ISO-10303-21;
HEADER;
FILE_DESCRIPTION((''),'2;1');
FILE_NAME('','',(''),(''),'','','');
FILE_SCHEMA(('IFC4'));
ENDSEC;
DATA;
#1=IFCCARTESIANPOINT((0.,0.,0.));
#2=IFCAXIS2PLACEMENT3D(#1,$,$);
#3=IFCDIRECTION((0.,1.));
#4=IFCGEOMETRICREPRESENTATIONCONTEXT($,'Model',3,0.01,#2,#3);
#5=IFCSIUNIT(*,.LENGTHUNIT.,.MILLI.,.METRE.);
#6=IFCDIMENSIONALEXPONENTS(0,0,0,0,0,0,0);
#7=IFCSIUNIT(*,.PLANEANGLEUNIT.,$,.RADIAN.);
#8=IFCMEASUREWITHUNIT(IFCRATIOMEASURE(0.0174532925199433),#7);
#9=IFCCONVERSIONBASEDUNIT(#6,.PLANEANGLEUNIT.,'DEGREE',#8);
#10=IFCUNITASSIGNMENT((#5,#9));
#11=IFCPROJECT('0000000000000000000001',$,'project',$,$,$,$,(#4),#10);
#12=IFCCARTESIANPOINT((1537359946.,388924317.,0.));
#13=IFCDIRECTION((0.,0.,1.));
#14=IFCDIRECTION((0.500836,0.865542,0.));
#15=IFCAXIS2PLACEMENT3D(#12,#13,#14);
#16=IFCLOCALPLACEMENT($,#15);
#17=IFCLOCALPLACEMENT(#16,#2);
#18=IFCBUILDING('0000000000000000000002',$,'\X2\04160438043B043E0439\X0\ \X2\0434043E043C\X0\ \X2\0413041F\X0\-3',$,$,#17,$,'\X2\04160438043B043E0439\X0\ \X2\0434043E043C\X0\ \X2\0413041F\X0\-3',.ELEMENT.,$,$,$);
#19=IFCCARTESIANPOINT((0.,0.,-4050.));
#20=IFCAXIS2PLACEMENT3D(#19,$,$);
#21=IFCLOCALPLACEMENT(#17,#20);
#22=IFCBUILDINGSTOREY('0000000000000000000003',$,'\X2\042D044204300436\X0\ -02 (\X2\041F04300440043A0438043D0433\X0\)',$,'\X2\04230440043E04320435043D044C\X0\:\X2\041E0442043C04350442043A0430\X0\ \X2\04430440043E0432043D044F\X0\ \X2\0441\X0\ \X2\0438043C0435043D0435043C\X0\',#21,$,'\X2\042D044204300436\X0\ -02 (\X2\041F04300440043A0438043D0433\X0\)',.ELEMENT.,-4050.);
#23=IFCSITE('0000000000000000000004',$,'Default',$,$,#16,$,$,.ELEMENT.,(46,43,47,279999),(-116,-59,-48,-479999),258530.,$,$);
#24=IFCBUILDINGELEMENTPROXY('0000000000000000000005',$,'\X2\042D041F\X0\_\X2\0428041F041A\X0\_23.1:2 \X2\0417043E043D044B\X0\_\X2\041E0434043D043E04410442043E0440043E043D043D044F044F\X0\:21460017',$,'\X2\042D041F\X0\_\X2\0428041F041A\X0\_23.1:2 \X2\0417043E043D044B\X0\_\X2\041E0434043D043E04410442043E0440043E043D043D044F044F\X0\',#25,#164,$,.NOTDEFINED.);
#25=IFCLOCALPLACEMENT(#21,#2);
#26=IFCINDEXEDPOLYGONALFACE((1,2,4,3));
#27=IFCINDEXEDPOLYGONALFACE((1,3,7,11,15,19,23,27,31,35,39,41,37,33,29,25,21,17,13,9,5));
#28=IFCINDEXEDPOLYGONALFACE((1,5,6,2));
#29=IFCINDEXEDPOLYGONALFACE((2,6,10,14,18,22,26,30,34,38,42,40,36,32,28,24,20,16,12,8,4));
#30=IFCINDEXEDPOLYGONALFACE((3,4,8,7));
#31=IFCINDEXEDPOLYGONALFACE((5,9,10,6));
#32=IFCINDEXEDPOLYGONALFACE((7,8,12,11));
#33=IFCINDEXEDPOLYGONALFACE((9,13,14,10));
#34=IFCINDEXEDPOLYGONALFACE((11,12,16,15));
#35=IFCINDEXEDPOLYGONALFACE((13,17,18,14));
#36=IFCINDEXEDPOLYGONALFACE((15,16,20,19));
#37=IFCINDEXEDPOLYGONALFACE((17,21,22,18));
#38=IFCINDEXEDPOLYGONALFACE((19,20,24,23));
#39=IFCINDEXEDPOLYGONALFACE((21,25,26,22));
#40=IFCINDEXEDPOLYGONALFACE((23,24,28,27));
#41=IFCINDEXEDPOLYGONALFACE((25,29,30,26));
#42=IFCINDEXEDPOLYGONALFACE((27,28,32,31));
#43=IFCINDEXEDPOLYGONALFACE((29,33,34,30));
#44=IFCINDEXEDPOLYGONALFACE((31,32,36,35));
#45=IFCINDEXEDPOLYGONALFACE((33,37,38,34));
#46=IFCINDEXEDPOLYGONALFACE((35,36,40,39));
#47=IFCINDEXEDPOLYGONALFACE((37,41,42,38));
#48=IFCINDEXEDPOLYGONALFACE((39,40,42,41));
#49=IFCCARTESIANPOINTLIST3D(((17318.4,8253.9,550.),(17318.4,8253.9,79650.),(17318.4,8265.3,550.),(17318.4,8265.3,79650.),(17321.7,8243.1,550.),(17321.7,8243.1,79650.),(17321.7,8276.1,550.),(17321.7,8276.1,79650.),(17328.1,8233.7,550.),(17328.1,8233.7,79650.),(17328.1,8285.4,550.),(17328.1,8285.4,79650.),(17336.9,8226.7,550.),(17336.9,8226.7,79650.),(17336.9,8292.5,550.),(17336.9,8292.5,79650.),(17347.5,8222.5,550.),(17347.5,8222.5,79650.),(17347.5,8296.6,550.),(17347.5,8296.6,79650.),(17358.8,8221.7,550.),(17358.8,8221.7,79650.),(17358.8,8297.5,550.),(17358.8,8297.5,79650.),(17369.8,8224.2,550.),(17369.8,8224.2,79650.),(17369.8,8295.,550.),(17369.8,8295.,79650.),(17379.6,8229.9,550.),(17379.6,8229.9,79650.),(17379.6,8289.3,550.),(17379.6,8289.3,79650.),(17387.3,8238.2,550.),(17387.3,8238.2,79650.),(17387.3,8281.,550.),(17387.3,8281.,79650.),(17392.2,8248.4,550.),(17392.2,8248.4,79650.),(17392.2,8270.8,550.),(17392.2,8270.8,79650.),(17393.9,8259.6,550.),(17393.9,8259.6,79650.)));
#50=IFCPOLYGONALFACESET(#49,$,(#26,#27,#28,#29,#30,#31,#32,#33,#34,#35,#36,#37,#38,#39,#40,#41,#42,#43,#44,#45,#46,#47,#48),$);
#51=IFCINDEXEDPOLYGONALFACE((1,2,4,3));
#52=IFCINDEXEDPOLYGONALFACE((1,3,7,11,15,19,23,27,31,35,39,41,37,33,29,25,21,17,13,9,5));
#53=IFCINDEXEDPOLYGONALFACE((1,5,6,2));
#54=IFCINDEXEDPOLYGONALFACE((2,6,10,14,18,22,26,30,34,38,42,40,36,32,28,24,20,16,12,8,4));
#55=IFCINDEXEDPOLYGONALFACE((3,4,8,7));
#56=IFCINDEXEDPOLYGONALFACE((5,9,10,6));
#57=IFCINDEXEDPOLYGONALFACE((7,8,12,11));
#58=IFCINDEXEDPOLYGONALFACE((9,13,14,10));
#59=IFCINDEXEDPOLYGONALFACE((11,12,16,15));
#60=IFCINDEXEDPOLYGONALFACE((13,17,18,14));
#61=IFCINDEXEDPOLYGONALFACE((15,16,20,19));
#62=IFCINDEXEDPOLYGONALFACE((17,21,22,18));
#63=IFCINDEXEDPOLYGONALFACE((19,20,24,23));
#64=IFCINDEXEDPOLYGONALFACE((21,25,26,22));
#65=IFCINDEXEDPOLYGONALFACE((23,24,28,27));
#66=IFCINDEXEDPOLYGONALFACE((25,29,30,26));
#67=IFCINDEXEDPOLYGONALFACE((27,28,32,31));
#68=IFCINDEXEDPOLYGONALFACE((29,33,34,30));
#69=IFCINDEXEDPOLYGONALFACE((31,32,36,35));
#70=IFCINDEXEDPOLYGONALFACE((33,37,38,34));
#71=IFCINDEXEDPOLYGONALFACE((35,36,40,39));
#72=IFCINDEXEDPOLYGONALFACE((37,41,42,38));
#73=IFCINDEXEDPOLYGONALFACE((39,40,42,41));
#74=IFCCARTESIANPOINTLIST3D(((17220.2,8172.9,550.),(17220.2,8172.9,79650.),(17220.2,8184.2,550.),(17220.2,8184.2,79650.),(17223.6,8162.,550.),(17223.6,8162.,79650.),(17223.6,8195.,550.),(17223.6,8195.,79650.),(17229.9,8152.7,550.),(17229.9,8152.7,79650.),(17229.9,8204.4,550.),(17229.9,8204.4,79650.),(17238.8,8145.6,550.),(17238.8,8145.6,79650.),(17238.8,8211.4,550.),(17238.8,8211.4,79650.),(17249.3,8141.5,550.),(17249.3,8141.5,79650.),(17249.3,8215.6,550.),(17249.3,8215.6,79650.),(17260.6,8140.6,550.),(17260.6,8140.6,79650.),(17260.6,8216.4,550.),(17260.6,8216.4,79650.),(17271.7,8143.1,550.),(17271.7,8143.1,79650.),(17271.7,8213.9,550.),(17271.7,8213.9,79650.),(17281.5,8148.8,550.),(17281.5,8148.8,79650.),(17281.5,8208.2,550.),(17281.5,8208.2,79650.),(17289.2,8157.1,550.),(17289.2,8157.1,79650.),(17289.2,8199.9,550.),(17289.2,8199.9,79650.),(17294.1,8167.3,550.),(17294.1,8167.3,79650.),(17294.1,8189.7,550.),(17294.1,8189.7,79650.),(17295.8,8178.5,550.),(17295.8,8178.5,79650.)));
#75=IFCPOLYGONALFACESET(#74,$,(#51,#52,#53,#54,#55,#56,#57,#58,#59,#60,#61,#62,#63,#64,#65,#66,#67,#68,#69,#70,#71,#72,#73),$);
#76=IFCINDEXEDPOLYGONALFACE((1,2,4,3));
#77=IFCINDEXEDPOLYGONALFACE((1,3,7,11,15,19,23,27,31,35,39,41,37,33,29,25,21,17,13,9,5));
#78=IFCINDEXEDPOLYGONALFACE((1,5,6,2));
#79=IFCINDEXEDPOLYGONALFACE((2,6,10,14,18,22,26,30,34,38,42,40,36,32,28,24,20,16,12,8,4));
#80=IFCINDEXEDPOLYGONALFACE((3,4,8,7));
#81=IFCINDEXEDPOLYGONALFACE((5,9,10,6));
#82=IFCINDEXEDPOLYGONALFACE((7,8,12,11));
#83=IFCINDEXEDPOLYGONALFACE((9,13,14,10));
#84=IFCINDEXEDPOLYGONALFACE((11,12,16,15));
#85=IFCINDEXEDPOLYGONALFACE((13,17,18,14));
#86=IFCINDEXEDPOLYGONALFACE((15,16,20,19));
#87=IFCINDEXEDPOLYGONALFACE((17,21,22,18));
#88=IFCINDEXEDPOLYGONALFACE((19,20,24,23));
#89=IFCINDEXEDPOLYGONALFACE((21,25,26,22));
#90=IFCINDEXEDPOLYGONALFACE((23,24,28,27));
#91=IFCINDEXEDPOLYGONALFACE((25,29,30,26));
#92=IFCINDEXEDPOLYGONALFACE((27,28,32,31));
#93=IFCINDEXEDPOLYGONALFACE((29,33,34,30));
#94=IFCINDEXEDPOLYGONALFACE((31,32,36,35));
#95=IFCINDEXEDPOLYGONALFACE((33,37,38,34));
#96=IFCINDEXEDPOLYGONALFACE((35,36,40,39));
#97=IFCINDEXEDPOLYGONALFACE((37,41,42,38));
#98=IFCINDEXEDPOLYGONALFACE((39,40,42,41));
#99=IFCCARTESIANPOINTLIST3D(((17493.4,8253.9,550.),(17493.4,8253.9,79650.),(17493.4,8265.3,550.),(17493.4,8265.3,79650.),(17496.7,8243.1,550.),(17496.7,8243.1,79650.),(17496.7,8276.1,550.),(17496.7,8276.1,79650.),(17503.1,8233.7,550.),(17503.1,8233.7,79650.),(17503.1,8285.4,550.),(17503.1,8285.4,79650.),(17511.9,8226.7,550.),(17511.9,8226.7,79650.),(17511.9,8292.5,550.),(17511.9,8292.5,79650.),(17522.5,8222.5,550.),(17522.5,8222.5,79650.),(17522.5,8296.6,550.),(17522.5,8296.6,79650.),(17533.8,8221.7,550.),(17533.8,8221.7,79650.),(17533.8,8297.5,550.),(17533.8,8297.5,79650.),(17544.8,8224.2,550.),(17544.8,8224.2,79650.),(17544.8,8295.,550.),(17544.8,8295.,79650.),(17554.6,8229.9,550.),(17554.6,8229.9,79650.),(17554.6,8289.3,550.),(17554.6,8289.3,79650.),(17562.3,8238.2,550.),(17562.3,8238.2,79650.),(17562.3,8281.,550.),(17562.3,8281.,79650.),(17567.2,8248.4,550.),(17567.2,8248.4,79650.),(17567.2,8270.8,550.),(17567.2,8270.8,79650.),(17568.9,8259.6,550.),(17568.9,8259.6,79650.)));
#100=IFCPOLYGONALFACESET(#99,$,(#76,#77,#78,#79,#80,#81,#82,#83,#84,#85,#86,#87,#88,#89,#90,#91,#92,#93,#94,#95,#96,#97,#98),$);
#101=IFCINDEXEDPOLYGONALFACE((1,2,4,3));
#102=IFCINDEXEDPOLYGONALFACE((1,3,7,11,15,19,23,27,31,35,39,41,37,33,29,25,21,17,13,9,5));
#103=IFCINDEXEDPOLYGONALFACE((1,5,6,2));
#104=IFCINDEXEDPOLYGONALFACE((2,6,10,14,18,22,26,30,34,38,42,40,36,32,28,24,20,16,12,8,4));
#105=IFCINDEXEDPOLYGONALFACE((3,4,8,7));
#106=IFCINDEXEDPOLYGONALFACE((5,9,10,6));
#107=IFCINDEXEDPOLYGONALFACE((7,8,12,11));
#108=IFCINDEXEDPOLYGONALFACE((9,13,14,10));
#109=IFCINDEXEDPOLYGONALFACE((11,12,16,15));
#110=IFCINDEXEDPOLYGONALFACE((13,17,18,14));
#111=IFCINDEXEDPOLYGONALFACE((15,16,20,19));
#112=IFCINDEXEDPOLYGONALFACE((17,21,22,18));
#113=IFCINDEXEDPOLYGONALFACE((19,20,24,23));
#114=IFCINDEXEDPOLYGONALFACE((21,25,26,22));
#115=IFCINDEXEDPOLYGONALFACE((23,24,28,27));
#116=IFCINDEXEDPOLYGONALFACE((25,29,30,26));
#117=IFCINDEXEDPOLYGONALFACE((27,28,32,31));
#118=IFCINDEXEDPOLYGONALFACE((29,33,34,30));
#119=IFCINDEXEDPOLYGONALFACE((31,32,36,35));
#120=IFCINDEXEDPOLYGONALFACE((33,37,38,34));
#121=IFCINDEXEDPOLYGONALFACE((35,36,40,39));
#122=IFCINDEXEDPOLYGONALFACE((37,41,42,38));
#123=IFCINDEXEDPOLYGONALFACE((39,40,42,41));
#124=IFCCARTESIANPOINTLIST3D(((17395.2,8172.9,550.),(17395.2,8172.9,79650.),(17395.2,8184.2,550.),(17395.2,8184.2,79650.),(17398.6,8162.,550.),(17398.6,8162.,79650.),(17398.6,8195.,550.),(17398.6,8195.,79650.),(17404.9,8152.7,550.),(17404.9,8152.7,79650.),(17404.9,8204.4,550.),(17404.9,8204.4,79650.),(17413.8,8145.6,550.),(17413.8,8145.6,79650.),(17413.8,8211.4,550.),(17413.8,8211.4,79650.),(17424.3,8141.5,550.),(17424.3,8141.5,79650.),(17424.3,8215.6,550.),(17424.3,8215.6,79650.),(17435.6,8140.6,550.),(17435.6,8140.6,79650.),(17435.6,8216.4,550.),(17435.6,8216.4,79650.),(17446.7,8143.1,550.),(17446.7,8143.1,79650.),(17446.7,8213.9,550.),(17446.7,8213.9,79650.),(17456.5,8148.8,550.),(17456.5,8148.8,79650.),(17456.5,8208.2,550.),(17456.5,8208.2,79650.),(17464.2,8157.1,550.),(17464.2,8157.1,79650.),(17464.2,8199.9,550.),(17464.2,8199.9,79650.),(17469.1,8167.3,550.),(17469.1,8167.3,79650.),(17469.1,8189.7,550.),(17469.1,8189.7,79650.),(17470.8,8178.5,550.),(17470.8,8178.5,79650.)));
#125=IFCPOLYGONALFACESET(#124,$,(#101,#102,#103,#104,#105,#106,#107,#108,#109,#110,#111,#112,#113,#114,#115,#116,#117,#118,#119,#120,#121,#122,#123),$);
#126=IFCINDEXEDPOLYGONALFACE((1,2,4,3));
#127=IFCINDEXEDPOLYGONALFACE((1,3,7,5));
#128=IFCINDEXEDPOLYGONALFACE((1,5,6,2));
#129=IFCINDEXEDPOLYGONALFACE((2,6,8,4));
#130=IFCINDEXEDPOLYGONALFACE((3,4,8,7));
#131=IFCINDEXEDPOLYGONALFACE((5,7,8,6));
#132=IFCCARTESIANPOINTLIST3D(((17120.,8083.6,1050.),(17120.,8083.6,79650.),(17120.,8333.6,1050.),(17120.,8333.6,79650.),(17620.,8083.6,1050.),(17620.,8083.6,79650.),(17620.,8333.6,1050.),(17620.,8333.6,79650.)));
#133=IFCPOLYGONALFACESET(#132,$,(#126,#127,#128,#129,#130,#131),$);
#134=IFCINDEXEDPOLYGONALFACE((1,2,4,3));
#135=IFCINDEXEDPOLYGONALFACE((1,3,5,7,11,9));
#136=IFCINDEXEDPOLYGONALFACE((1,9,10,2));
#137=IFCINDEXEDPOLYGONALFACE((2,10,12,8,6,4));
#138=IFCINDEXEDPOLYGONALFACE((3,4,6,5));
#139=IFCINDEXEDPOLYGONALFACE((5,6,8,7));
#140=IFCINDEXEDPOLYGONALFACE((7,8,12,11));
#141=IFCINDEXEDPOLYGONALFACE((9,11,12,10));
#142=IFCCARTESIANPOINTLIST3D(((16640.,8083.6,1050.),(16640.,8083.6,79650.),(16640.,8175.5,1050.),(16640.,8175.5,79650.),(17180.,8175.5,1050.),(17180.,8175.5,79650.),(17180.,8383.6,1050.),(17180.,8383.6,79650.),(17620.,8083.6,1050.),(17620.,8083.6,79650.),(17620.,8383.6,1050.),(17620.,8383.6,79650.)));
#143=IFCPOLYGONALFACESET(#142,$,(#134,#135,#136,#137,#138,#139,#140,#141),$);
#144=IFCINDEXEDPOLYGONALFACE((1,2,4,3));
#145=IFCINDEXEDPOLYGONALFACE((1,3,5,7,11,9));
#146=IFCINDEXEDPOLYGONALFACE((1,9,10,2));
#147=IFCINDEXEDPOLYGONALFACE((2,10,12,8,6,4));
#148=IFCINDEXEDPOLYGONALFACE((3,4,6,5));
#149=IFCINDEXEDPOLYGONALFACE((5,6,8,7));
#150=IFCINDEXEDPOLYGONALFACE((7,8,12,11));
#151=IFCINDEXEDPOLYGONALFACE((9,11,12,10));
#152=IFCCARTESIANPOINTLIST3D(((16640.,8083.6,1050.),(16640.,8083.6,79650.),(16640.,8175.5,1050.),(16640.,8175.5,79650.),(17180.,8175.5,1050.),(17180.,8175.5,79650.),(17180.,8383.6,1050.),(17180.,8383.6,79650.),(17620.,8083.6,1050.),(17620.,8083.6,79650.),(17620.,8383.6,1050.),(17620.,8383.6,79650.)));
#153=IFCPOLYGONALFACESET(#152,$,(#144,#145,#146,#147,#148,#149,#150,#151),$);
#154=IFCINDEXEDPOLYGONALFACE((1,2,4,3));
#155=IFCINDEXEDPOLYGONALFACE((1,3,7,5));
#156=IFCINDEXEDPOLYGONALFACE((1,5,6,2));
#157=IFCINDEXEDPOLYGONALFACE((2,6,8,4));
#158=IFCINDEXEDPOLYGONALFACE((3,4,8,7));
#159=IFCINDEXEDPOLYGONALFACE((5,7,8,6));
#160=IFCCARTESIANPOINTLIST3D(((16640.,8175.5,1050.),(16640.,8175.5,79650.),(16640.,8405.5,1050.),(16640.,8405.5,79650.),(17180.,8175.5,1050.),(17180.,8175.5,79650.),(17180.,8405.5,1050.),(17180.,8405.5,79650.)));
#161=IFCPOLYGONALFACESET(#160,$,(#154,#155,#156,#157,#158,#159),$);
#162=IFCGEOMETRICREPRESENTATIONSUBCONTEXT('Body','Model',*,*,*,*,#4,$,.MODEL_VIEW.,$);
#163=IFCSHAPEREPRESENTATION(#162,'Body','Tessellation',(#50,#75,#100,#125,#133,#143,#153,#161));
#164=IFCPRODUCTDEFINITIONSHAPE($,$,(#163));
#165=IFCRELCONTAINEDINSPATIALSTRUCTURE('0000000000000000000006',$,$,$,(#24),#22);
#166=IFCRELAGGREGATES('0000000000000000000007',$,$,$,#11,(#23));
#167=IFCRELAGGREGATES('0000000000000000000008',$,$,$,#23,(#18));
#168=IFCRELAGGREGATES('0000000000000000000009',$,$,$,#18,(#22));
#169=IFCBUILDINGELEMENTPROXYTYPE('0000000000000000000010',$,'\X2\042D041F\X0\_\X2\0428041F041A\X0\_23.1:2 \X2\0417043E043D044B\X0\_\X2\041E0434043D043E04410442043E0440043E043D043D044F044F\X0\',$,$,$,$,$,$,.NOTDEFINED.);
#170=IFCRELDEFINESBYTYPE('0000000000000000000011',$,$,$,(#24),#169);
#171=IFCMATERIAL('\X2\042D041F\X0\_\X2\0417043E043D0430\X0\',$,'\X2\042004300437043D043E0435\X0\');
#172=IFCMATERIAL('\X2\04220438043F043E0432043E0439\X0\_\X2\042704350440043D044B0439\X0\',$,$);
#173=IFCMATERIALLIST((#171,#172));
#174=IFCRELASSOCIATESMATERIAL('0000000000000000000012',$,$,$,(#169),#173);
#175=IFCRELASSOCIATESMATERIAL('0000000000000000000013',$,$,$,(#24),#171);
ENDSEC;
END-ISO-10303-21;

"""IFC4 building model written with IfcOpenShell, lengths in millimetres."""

from ifc_helpers import new_model, entity, si_unit, converted_unit, direction, frame, frame_2d, origin, origin_2d_with_axis, place, context, subcontext, project, spatial, polyline, rectangle, circle, outline, extrude, source, transform, mapped, material, material_list, type_object, type_shapes, element, save


model = new_model("IFC4")

# Units and contexts
model_context = context("Model", 3, precision=0.01, world=origin(), true_north=direction((0.0, 1.0)))
body_context = subcontext(model_context, "Body", "Model", "MODEL_VIEW")
ifc_project = project(units=[si_unit("LENGTHUNIT", "METRE", prefix="MILLI"), converted_unit("PLANEANGLEUNIT", "DEGREE", entity("IfcRatioMeasure", 0.0174532925199433), si_unit("PLANEANGLEUNIT", "RADIAN"), dimensions=[0, 0, 0, 0, 0, 0, 0])], contexts=[model_context])

# Site, building, storey
site_placement = place(None, frame((1537359946.0, 388924317.0, 0.0), z_axis=(0.0, 0.0, 1.0), x_axis=(0.500836, 0.865542, 0.0)))
site = spatial("IfcSite", under=ifc_project, at=site_placement, Name="Default", CompositionType="ELEMENT", RefLatitude=(46, 43, 47, 279999), RefLongitude=(-116, -59, -48, -479999), RefElevation=258530.0)
building_placement = place(site_placement, origin())
building = spatial("IfcBuilding", under=site, at=building_placement, Name="Жилой дом ГП-3", LongName="Жилой дом ГП-3", CompositionType="ELEMENT")
storey_placement = place(building_placement, frame((0.0, 0.0, -4050.0)))
storey = spatial("IfcBuildingStorey", under=building, at=storey_placement, Name="Этаж -02 (Паркинг)", ObjectType="Уровень:Отметка уровня с именем", LongName="Этаж -02 (Паркинг)", CompositionType="ELEMENT", Elevation=-4050.0)

# Building element proxy
ifc_material_1 = material(Name="ЭП_Зона", Category="Разное")
ifc_material_2 = material(Name="Типовой_Черный")
ifc_material_list_1 = material_list([ifc_material_1, ifc_material_2])
building_element_proxy_type_1 = type_object("IfcBuildingElementProxyType", Name="ЭП_ШПК_23.1:2 Зоны_Односторонняя", PredefinedType="NOTDEFINED", material=ifc_material_list_1)
shared_shape_1 = source(origin(), body_context, "Body", "SweptSolid", [
    extrude(circle(Radius=38.0, at=frame_2d((0.0, 0.0), x_axis=(1.0, 0.0))), frame((264.1, -176.0, -3500.0), z_axis=(0.0, 0.0, 1.0), x_axis=(-1.0, 0.0, 0.0)), (0.0, 0.0, 1.0), 79100.0),
    extrude(circle(Radius=38.0, at=frame_2d((0.0, 0.0), x_axis=(1.0, 0.0))), frame((362.2, -94.9, -3500.0), z_axis=(0.0, 0.0, 1.0), x_axis=(-1.0, 0.0, 0.0)), (0.0, 0.0, 1.0), 79100.0),
    extrude(circle(Radius=38.0, at=frame_2d((0.0, 0.0), x_axis=(1.0, 0.0))), frame((89.1, -176.0, -3500.0), z_axis=(0.0, 0.0, 1.0), x_axis=(-1.0, 0.0, 0.0)), (0.0, 0.0, 1.0), 79100.0),
    extrude(circle(Radius=38.0, at=frame_2d((0.0, 0.0), x_axis=(1.0, 0.0))), frame((187.2, -94.9, -3500.0), z_axis=(0.0, 0.0, 1.0), x_axis=(-1.0, 0.0, 0.0)), (0.0, 0.0, 1.0), 79100.0),
    extrude(rectangle(XDim=500.0, YDim=250.0, at=origin_2d_with_axis()), frame((250.0, -125.0, -3000.0), z_axis=(0.0, 0.0, 1.0), x_axis=(-1.0, 0.0, 0.0)), (0.0, 0.0, 1.0), 78600.0),
    extrude(outline(polyline([(-506.7, -130.6), (473.3, -130.6), (473.3, 169.4), (33.3, 169.4), (33.3, -38.7), (-506.7, -38.7), (-506.7, -130.6)])), frame((473.3, -130.6, -3000.0), z_axis=(0.0, 0.0, 1.0), x_axis=(-1.0, 0.0, 0.0)), (0.0, 0.0, 1.0), 78600.0),
    extrude(outline(polyline([(-506.7, -130.6), (473.3, -130.6), (473.3, 169.4), (33.3, 169.4), (33.3, -38.7), (-506.7, -38.7), (-506.7, -130.6)])), frame((473.3, -130.6, -3000.0), z_axis=(0.0, 0.0, 1.0), x_axis=(-1.0, 0.0, 0.0)), (0.0, 0.0, 1.0), 78600.0),
    extrude(rectangle(XDim=230.0, YDim=540.0, at=frame_2d((0.0, 0.0), x_axis=(1.0, 0.0))), frame((710.0, -206.9, -3000.0), z_axis=(0.0, 0.0, 1.0), x_axis=(0.0, 1.0, 0.0)), (0.0, 0.0, 1.0), 78600.0),
])
type_shapes(building_element_proxy_type_1, [shared_shape_1])
proxy_1_placement = place(storey_placement, frame((17620.0, 8083.6, 4050.0), z_axis=(0.0, 0.0, 1.0), x_axis=(-1.0, 0.0, 0.0)))
element("IfcBuildingElementProxy", 1, at=proxy_1_placement, inside=storey, type_object=building_element_proxy_type_1, material=ifc_material_1, Name="ЭП_ШПК_23.1:2 Зоны_Односторонняя:21460017", ObjectType="ЭП_ШПК_23.1:2 Зоны_Односторонняя", PredefinedType="NOTDEFINED", context=body_context, shape_type="MappedRepresentation", body=[
    mapped(shared_shape_1, transform((0.0, 0.0, 0.0), scale=1.0)),
])

save(model, "model.ifc")
